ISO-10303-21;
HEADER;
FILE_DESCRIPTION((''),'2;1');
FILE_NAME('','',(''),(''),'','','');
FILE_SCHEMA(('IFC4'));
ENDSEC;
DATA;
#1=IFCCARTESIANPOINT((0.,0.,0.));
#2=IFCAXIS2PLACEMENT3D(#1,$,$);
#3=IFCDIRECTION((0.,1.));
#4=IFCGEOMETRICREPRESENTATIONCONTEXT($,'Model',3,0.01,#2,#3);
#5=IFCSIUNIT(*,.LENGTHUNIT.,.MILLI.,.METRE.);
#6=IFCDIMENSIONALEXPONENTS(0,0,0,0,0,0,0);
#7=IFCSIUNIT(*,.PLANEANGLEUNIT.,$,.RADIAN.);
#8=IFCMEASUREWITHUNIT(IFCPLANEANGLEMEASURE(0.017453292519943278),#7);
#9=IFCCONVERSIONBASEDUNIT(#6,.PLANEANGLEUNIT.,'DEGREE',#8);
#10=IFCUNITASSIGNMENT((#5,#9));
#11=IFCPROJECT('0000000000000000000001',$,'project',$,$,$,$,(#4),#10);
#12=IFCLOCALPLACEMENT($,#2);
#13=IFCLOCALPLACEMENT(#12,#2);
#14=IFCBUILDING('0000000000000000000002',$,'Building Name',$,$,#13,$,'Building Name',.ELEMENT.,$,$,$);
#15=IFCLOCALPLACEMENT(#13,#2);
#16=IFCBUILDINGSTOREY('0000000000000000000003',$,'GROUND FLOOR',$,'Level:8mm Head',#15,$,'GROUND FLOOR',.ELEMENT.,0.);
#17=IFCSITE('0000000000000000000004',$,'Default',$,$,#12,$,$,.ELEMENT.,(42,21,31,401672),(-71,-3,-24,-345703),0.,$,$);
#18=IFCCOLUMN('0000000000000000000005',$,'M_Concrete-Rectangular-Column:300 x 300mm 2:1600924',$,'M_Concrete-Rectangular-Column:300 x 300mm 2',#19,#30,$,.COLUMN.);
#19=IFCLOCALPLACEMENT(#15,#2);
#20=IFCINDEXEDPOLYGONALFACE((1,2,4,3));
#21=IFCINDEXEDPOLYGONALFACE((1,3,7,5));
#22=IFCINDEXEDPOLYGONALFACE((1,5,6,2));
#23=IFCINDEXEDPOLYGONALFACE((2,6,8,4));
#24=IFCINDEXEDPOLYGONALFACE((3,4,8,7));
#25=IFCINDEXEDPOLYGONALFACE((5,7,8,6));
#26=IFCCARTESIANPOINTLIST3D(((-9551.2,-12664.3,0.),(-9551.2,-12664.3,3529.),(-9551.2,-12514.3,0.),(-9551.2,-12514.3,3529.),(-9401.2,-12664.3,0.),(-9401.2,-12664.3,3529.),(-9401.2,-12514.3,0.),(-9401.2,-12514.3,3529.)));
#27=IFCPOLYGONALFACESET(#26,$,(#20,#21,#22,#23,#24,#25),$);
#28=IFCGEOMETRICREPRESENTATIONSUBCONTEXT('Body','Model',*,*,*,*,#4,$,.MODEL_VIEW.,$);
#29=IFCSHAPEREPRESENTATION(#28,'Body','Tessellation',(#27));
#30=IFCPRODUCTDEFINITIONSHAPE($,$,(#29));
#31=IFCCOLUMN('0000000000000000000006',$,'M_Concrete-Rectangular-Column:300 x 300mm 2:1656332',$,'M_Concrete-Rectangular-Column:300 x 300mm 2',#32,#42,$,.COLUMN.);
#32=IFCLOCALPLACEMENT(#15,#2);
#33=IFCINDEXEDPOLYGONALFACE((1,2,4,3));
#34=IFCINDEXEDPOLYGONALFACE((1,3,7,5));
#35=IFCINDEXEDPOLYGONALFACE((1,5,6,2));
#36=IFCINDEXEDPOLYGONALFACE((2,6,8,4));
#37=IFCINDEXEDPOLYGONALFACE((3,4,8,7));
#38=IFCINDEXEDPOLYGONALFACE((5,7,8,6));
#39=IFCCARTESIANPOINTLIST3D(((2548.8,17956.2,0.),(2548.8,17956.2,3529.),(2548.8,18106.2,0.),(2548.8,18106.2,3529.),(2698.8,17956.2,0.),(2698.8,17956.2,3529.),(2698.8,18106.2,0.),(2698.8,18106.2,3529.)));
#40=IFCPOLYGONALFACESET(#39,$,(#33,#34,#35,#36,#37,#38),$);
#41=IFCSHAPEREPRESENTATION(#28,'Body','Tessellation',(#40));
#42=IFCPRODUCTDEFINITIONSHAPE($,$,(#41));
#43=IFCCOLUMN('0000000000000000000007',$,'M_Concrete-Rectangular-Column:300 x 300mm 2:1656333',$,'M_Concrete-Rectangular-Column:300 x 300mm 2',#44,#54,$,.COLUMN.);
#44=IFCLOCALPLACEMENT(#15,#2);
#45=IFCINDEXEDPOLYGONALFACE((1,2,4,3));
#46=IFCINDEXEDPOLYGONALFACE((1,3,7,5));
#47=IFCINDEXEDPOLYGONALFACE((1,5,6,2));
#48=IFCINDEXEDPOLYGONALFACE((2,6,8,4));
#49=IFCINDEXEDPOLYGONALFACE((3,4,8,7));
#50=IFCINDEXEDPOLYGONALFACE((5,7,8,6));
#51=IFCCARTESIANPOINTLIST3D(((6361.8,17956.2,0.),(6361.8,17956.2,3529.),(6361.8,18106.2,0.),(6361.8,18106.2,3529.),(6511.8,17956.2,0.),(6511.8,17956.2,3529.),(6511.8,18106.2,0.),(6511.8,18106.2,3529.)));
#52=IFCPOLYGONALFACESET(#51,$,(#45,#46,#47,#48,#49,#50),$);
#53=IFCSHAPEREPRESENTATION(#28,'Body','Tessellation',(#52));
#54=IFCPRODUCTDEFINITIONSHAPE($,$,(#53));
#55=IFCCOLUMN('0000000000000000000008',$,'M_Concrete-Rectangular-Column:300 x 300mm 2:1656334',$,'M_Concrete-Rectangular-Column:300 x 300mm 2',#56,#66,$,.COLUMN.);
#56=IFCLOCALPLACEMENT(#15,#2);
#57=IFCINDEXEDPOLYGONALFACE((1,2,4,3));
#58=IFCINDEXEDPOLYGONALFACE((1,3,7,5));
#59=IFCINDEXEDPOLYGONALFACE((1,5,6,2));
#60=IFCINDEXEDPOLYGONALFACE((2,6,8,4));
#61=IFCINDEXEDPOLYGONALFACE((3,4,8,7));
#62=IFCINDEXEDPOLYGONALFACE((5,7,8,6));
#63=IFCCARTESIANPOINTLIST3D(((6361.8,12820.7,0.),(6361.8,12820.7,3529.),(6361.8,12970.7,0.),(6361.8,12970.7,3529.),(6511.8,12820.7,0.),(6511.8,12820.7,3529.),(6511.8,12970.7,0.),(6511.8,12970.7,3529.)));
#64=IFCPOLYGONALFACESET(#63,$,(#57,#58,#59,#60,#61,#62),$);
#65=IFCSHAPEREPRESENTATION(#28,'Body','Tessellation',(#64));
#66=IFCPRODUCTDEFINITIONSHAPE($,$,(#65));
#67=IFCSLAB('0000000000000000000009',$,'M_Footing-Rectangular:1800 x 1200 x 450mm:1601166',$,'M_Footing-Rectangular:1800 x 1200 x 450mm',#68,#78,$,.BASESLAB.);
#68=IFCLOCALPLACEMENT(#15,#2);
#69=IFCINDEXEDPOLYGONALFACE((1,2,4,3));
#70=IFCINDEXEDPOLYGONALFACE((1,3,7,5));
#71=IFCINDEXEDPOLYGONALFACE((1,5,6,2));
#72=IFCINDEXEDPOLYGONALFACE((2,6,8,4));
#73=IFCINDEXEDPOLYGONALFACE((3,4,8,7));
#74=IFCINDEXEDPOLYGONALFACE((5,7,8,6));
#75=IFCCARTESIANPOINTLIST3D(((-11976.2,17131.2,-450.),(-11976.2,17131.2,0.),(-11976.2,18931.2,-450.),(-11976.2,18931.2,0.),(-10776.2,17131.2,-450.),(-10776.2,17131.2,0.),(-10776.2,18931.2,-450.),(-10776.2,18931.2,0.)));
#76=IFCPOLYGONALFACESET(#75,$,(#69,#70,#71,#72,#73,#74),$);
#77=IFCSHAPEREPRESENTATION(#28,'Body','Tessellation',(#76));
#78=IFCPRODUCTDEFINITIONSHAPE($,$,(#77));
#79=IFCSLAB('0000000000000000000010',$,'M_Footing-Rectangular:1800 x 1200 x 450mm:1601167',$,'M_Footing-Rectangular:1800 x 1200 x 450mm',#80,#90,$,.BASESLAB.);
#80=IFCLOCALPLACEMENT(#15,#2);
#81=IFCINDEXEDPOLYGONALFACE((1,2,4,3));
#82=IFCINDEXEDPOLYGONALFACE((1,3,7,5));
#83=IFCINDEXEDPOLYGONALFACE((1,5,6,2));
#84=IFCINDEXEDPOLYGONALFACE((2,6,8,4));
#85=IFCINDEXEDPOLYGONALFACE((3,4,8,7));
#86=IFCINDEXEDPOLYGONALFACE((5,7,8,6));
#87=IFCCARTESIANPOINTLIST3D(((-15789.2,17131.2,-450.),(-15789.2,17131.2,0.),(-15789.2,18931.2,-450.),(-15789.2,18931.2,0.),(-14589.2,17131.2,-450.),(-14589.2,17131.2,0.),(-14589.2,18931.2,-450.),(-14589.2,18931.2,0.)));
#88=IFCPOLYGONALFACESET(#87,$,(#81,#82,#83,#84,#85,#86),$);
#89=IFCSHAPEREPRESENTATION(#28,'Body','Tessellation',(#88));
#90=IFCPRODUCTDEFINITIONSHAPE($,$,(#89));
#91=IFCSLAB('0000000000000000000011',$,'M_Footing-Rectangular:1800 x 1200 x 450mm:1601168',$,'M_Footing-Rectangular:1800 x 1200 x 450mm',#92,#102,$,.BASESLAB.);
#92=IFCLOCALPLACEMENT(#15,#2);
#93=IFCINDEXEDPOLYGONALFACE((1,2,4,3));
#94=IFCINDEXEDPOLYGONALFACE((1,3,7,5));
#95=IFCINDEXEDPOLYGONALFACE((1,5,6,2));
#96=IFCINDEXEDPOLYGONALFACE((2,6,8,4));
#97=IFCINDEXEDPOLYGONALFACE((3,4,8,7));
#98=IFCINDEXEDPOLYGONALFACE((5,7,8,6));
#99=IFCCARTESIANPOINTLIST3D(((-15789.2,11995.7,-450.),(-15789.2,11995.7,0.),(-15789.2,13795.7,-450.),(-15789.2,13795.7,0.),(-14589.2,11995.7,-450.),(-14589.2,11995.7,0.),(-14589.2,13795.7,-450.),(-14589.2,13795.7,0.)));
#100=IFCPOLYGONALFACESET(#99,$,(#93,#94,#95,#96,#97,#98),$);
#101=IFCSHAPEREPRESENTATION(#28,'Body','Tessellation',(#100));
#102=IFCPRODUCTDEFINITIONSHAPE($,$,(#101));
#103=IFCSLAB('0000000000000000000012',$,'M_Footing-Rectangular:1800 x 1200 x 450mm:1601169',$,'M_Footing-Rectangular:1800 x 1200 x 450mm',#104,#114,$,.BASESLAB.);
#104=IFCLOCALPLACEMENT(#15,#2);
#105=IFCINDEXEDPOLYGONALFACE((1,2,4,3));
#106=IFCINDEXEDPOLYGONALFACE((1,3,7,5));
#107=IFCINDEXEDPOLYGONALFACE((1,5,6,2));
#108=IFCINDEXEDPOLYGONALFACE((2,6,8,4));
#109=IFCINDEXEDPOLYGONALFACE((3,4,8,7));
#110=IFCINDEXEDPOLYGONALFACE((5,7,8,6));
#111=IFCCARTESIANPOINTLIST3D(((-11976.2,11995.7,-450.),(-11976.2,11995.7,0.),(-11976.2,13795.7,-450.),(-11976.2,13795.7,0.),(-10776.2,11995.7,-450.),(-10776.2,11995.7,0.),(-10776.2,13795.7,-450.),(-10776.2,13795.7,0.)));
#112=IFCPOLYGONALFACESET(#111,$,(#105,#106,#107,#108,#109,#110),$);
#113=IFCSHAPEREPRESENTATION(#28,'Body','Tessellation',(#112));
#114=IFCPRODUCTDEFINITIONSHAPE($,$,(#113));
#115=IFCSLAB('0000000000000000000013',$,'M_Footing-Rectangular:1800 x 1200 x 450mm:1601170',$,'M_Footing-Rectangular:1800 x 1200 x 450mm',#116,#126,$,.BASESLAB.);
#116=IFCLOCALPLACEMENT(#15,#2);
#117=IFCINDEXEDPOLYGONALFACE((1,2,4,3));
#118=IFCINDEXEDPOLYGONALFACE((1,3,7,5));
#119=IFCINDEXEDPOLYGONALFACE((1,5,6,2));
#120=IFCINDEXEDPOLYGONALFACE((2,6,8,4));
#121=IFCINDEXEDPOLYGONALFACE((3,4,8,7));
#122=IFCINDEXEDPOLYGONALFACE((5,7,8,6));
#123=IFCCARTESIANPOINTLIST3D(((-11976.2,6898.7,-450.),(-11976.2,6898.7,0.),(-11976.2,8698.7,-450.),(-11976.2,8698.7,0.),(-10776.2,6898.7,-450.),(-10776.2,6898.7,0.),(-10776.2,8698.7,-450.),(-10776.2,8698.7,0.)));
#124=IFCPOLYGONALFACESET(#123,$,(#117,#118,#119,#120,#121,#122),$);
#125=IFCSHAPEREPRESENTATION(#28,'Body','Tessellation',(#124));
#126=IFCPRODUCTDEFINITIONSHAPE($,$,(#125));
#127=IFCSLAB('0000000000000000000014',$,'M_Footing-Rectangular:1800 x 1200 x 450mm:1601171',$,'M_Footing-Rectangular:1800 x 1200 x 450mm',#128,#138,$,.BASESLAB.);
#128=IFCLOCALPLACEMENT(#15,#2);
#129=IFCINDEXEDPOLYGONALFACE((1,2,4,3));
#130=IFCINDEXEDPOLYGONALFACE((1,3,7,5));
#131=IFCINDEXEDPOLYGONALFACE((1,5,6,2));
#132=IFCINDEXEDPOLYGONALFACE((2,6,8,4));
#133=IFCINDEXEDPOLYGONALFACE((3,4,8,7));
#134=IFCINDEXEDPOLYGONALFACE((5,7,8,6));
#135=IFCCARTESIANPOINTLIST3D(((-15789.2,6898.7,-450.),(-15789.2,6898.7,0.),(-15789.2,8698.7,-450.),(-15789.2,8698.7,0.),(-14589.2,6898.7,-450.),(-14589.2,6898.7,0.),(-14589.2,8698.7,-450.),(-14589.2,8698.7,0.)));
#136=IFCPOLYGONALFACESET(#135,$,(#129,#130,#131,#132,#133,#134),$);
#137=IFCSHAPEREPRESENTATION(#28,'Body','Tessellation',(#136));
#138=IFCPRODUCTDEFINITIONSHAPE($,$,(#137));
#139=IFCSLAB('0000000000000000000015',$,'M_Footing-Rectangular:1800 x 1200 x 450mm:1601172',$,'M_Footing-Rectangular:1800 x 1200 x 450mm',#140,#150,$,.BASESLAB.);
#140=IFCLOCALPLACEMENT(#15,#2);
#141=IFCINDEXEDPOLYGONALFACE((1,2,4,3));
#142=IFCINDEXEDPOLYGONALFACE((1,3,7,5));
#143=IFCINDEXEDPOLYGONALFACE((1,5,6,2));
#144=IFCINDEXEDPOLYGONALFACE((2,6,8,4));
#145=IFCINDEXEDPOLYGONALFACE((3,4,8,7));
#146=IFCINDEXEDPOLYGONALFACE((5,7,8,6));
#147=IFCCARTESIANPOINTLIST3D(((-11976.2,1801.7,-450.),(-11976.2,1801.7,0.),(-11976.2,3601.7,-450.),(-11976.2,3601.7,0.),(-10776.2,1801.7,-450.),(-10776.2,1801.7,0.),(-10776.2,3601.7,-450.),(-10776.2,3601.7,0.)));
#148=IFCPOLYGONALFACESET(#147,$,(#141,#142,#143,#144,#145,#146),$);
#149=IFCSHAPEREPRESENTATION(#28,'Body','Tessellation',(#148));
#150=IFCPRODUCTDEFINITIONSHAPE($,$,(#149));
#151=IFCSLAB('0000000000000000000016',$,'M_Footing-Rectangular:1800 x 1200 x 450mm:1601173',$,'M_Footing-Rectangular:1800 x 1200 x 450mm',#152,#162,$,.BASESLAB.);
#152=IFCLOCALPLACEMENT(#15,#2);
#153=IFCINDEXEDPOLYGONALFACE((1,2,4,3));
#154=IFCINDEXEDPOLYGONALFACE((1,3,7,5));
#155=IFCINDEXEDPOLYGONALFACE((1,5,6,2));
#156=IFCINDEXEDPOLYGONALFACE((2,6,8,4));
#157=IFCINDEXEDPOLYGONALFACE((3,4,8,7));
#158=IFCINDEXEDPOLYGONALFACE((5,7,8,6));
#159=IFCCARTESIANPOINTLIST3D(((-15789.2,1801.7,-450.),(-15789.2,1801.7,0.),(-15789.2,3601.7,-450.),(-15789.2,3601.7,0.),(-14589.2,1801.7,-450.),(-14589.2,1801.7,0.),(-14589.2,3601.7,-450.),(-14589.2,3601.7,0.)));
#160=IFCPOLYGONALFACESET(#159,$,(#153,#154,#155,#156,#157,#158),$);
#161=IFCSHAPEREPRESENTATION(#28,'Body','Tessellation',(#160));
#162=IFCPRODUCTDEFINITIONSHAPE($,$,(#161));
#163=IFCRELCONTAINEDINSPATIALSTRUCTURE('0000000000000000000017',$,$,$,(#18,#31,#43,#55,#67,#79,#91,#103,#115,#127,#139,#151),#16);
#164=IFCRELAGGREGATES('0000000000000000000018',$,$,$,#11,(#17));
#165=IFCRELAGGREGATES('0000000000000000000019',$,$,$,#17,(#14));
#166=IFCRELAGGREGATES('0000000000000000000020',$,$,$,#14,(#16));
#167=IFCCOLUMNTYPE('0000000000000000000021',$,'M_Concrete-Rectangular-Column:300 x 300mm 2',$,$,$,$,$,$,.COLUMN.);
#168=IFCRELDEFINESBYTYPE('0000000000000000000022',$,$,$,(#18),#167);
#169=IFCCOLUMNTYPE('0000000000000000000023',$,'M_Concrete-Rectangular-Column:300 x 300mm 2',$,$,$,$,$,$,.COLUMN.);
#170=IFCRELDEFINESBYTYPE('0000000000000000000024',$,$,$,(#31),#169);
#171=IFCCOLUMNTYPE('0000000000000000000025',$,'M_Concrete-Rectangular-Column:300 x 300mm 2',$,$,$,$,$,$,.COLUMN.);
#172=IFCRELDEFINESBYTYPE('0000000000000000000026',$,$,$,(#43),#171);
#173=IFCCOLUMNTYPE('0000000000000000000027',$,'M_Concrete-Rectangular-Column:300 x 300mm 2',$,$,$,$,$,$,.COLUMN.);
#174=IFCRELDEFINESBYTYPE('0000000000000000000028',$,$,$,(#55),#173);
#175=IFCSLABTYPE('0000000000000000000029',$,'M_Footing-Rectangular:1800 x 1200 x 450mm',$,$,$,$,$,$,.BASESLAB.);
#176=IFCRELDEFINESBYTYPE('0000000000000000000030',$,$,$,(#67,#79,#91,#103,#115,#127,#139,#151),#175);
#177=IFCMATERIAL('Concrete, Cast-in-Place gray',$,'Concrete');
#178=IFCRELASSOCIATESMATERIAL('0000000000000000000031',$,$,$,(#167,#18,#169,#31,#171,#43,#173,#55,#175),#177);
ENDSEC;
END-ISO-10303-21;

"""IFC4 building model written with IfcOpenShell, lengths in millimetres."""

from ifc_helpers import new_model, entity, si_unit, converted_unit, direction, frame, origin, place, context, subcontext, project, spatial, indexed_curve, outline, extrude, source, transform, mapped, material, type_object, type_shapes, element, save


model = new_model("IFC4")

# Units and contexts
model_context = context("Model", 3, precision=0.01, world=origin(), true_north=direction((0.0, 1.0)))
body_context = subcontext(model_context, "Body", "Model", "MODEL_VIEW")
ifc_project = project(units=[si_unit("LENGTHUNIT", "METRE", prefix="MILLI"), converted_unit("PLANEANGLEUNIT", "DEGREE", entity("IfcPlaneAngleMeasure", 0.017453292519943278), si_unit("PLANEANGLEUNIT", "RADIAN"), dimensions=[0, 0, 0, 0, 0, 0, 0])], contexts=[model_context])

# Site, building, storey
site_placement = place(None, origin())
site = spatial("IfcSite", under=ifc_project, at=site_placement, Name="Default", CompositionType="ELEMENT", RefLatitude=(42, 21, 31, 401672), RefLongitude=(-71, -3, -24, -345703), RefElevation=0.0)
building_placement = place(site_placement, origin())
building = spatial("IfcBuilding", under=site, at=building_placement, Name="Building Name", LongName="Building Name", CompositionType="ELEMENT")
storey_placement = place(building_placement, origin())
storey = spatial("IfcBuildingStorey", under=building, at=storey_placement, Name="GROUND FLOOR", ObjectType="Level:8mm Head", LongName="GROUND FLOOR", CompositionType="ELEMENT", Elevation=0.0)

# Columns
ifc_material_1 = material(Name="Concrete, Cast-in-Place gray", Category="Concrete")
column_type_1 = type_object("IfcColumnType", Name="M_Concrete-Rectangular-Column:300 x 300mm 2", PredefinedType="COLUMN", material=ifc_material_1)
shared_shape_1 = source(origin(), body_context, "Body", "SweptSolid", [
    extrude(outline(indexed_curve([(-75.0, -75.0), (75.0, -75.0), (75.0, 75.0), (-75.0, 75.0), (-75.0, -75.0)], self_intersect=False)), frame((-9476.2, -12589.3, 0.0), z_axis=(0.0, 0.0, 1.0), x_axis=(-1.0, 0.0, 0.0)), (0.0, 0.0, 1.0), 3529.0),
])
type_shapes(column_type_1, [shared_shape_1])
column_1_placement = place(storey_placement, origin())
element("IfcColumn", 1, at=column_1_placement, inside=storey, type_object=column_type_1, material=ifc_material_1, Name="M_Concrete-Rectangular-Column:300 x 300mm 2:1600924", ObjectType="M_Concrete-Rectangular-Column:300 x 300mm 2", PredefinedType="COLUMN", context=body_context, shape_type="MappedRepresentation", body=[
    mapped(shared_shape_1, transform((0.0, 0.0, 0.0), scale=1.0)),
])
column_type_2 = type_object("IfcColumnType", Name="M_Concrete-Rectangular-Column:300 x 300mm 2", PredefinedType="COLUMN", material=ifc_material_1)
shared_shape_2 = source(origin(), body_context, "Body", "SweptSolid", [
    extrude(outline(indexed_curve([(-75.0, -75.0), (75.0, -75.0), (75.0, 75.0), (-75.0, 75.0), (-75.0, -75.0)], self_intersect=False)), frame((2623.8, 18031.2, 0.0)), (0.0, 0.0, 1.0), 3529.0),
])
type_shapes(column_type_2, [shared_shape_2])
column_2_placement = place(storey_placement, origin())
element("IfcColumn", 2, at=column_2_placement, inside=storey, type_object=column_type_2, material=ifc_material_1, Name="M_Concrete-Rectangular-Column:300 x 300mm 2:1656332", ObjectType="M_Concrete-Rectangular-Column:300 x 300mm 2", PredefinedType="COLUMN", context=body_context, shape_type="MappedRepresentation", body=[
    mapped(shared_shape_2, transform((0.0, 0.0, 0.0), scale=1.0)),
])
column_type_3 = type_object("IfcColumnType", Name="M_Concrete-Rectangular-Column:300 x 300mm 2", PredefinedType="COLUMN", material=ifc_material_1)
shared_shape_3 = source(origin(), body_context, "Body", "SweptSolid", [
    extrude(outline(indexed_curve([(-75.0, -75.0), (75.0, -75.0), (75.0, 75.0), (-75.0, 75.0), (-75.0, -75.0)], self_intersect=False)), frame((6436.8, 18031.2, 0.0)), (0.0, 0.0, 1.0), 3529.0),
])
type_shapes(column_type_3, [shared_shape_3])
column_3_placement = place(storey_placement, origin())
element("IfcColumn", 3, at=column_3_placement, inside=storey, type_object=column_type_3, material=ifc_material_1, Name="M_Concrete-Rectangular-Column:300 x 300mm 2:1656333", ObjectType="M_Concrete-Rectangular-Column:300 x 300mm 2", PredefinedType="COLUMN", context=body_context, shape_type="MappedRepresentation", body=[
    mapped(shared_shape_3, transform((0.0, 0.0, 0.0), scale=1.0)),
])
column_type_4 = type_object("IfcColumnType", Name="M_Concrete-Rectangular-Column:300 x 300mm 2", PredefinedType="COLUMN", material=ifc_material_1)
shared_shape_4 = source(origin(), body_context, "Body", "SweptSolid", [
    extrude(outline(indexed_curve([(-75.0, -75.0), (75.0, -75.0), (75.0, 75.0), (-75.0, 75.0), (-75.0, -75.0)], self_intersect=False)), frame((6436.8, 12895.7, 0.0)), (0.0, 0.0, 1.0), 3529.0),
])
type_shapes(column_type_4, [shared_shape_4])
column_4_placement = place(storey_placement, origin())
element("IfcColumn", 4, at=column_4_placement, inside=storey, type_object=column_type_4, material=ifc_material_1, Name="M_Concrete-Rectangular-Column:300 x 300mm 2:1656334", ObjectType="M_Concrete-Rectangular-Column:300 x 300mm 2", PredefinedType="COLUMN", context=body_context, shape_type="MappedRepresentation", body=[
    mapped(shared_shape_4, transform((0.0, 0.0, 0.0), scale=1.0)),
])

# Slabs
slab_type_1 = type_object("IfcSlabType", Name="M_Footing-Rectangular:1800 x 1200 x 450mm", PredefinedType="BASESLAB", material=ifc_material_1)
slab_1_placement = place(storey_placement, origin())
element("IfcSlab", 5, at=slab_1_placement, inside=storey, type_object=slab_type_1, Name="M_Footing-Rectangular:1800 x 1200 x 450mm:1601166", ObjectType="M_Footing-Rectangular:1800 x 1200 x 450mm", PredefinedType="BASESLAB", context=body_context, shape_type="SweptSolid", body=[
    extrude(outline(indexed_curve([(-600.0, -900.0), (600.0, -900.0), (600.0, 900.0), (-600.0, 900.0), (-600.0, -900.0)], self_intersect=False)), frame((-11376.2, 18031.2, -450.0), z_axis=(0.0, 0.0, 1.0), x_axis=(-1.0, 0.0, 0.0)), (0.0, 0.0, 1.0), 450.0),
])
slab_2_placement = place(storey_placement, origin())
element("IfcSlab", 6, at=slab_2_placement, inside=storey, type_object=slab_type_1, Name="M_Footing-Rectangular:1800 x 1200 x 450mm:1601167", ObjectType="M_Footing-Rectangular:1800 x 1200 x 450mm", PredefinedType="BASESLAB", context=body_context, shape_type="SweptSolid", body=[
    extrude(outline(indexed_curve([(-600.0, -900.0), (600.0, -900.0), (600.0, 900.0), (-600.0, 900.0), (-600.0, -900.0)], self_intersect=False)), frame((-15189.2, 18031.2, -450.0), z_axis=(0.0, 0.0, 1.0), x_axis=(-1.0, 0.0, 0.0)), (0.0, 0.0, 1.0), 450.0),
])
slab_3_placement = place(storey_placement, origin())
element("IfcSlab", 7, at=slab_3_placement, inside=storey, type_object=slab_type_1, Name="M_Footing-Rectangular:1800 x 1200 x 450mm:1601168", ObjectType="M_Footing-Rectangular:1800 x 1200 x 450mm", PredefinedType="BASESLAB", context=body_context, shape_type="SweptSolid", body=[
    extrude(outline(indexed_curve([(-600.0, -900.0), (600.0, -900.0), (600.0, 900.0), (-600.0, 900.0), (-600.0, -900.0)], self_intersect=False)), frame((-15189.2, 12895.7, -450.0), z_axis=(0.0, 0.0, 1.0), x_axis=(-1.0, 0.0, 0.0)), (0.0, 0.0, 1.0), 450.0),
])
slab_4_placement = place(storey_placement, origin())
element("IfcSlab", 8, at=slab_4_placement, inside=storey, type_object=slab_type_1, Name="M_Footing-Rectangular:1800 x 1200 x 450mm:1601169", ObjectType="M_Footing-Rectangular:1800 x 1200 x 450mm", PredefinedType="BASESLAB", context=body_context, shape_type="SweptSolid", body=[
    extrude(outline(indexed_curve([(-600.0, -900.0), (600.0, -900.0), (600.0, 900.0), (-600.0, 900.0), (-600.0, -900.0)], self_intersect=False)), frame((-11376.2, 12895.7, -450.0), z_axis=(0.0, 0.0, 1.0), x_axis=(-1.0, 0.0, 0.0)), (0.0, 0.0, 1.0), 450.0),
])
slab_5_placement = place(storey_placement, origin())
element("IfcSlab", 9, at=slab_5_placement, inside=storey, type_object=slab_type_1, Name="M_Footing-Rectangular:1800 x 1200 x 450mm:1601170", ObjectType="M_Footing-Rectangular:1800 x 1200 x 450mm", PredefinedType="BASESLAB", context=body_context, shape_type="SweptSolid", body=[
    extrude(outline(indexed_curve([(-600.0, -900.0), (600.0, -900.0), (600.0, 900.0), (-600.0, 900.0), (-600.0, -900.0)], self_intersect=False)), frame((-11376.2, 7798.7, -450.0), z_axis=(0.0, 0.0, 1.0), x_axis=(-1.0, 0.0, 0.0)), (0.0, 0.0, 1.0), 450.0),
])
slab_6_placement = place(storey_placement, origin())
element("IfcSlab", 10, at=slab_6_placement, inside=storey, type_object=slab_type_1, Name="M_Footing-Rectangular:1800 x 1200 x 450mm:1601171", ObjectType="M_Footing-Rectangular:1800 x 1200 x 450mm", PredefinedType="BASESLAB", context=body_context, shape_type="SweptSolid", body=[
    extrude(outline(indexed_curve([(-600.0, -900.0), (600.0, -900.0), (600.0, 900.0), (-600.0, 900.0), (-600.0, -900.0)], self_intersect=False)), frame((-15189.2, 7798.7, -450.0), z_axis=(0.0, 0.0, 1.0), x_axis=(-1.0, 0.0, 0.0)), (0.0, 0.0, 1.0), 450.0),
])
slab_7_placement = place(storey_placement, origin())
element("IfcSlab", 11, at=slab_7_placement, inside=storey, type_object=slab_type_1, Name="M_Footing-Rectangular:1800 x 1200 x 450mm:1601172", ObjectType="M_Footing-Rectangular:1800 x 1200 x 450mm", PredefinedType="BASESLAB", context=body_context, shape_type="SweptSolid", body=[
    extrude(outline(indexed_curve([(-600.0, -900.0), (600.0, -900.0), (600.0, 900.0), (-600.0, 900.0), (-600.0, -900.0)], self_intersect=False)), frame((-11376.2, 2701.7, -450.0), z_axis=(0.0, 0.0, 1.0), x_axis=(-1.0, 0.0, 0.0)), (0.0, 0.0, 1.0), 450.0),
])
slab_8_placement = place(storey_placement, origin())
element("IfcSlab", 12, at=slab_8_placement, inside=storey, type_object=slab_type_1, Name="M_Footing-Rectangular:1800 x 1200 x 450mm:1601173", ObjectType="M_Footing-Rectangular:1800 x 1200 x 450mm", PredefinedType="BASESLAB", context=body_context, shape_type="SweptSolid", body=[
    extrude(outline(indexed_curve([(-600.0, -900.0), (600.0, -900.0), (600.0, 900.0), (-600.0, 900.0), (-600.0, -900.0)], self_intersect=False)), frame((-15189.2, 2701.7, -450.0), z_axis=(0.0, 0.0, 1.0), x_axis=(-1.0, 0.0, 0.0)), (0.0, 0.0, 1.0), 450.0),
])

save(model, "model.ifc")
